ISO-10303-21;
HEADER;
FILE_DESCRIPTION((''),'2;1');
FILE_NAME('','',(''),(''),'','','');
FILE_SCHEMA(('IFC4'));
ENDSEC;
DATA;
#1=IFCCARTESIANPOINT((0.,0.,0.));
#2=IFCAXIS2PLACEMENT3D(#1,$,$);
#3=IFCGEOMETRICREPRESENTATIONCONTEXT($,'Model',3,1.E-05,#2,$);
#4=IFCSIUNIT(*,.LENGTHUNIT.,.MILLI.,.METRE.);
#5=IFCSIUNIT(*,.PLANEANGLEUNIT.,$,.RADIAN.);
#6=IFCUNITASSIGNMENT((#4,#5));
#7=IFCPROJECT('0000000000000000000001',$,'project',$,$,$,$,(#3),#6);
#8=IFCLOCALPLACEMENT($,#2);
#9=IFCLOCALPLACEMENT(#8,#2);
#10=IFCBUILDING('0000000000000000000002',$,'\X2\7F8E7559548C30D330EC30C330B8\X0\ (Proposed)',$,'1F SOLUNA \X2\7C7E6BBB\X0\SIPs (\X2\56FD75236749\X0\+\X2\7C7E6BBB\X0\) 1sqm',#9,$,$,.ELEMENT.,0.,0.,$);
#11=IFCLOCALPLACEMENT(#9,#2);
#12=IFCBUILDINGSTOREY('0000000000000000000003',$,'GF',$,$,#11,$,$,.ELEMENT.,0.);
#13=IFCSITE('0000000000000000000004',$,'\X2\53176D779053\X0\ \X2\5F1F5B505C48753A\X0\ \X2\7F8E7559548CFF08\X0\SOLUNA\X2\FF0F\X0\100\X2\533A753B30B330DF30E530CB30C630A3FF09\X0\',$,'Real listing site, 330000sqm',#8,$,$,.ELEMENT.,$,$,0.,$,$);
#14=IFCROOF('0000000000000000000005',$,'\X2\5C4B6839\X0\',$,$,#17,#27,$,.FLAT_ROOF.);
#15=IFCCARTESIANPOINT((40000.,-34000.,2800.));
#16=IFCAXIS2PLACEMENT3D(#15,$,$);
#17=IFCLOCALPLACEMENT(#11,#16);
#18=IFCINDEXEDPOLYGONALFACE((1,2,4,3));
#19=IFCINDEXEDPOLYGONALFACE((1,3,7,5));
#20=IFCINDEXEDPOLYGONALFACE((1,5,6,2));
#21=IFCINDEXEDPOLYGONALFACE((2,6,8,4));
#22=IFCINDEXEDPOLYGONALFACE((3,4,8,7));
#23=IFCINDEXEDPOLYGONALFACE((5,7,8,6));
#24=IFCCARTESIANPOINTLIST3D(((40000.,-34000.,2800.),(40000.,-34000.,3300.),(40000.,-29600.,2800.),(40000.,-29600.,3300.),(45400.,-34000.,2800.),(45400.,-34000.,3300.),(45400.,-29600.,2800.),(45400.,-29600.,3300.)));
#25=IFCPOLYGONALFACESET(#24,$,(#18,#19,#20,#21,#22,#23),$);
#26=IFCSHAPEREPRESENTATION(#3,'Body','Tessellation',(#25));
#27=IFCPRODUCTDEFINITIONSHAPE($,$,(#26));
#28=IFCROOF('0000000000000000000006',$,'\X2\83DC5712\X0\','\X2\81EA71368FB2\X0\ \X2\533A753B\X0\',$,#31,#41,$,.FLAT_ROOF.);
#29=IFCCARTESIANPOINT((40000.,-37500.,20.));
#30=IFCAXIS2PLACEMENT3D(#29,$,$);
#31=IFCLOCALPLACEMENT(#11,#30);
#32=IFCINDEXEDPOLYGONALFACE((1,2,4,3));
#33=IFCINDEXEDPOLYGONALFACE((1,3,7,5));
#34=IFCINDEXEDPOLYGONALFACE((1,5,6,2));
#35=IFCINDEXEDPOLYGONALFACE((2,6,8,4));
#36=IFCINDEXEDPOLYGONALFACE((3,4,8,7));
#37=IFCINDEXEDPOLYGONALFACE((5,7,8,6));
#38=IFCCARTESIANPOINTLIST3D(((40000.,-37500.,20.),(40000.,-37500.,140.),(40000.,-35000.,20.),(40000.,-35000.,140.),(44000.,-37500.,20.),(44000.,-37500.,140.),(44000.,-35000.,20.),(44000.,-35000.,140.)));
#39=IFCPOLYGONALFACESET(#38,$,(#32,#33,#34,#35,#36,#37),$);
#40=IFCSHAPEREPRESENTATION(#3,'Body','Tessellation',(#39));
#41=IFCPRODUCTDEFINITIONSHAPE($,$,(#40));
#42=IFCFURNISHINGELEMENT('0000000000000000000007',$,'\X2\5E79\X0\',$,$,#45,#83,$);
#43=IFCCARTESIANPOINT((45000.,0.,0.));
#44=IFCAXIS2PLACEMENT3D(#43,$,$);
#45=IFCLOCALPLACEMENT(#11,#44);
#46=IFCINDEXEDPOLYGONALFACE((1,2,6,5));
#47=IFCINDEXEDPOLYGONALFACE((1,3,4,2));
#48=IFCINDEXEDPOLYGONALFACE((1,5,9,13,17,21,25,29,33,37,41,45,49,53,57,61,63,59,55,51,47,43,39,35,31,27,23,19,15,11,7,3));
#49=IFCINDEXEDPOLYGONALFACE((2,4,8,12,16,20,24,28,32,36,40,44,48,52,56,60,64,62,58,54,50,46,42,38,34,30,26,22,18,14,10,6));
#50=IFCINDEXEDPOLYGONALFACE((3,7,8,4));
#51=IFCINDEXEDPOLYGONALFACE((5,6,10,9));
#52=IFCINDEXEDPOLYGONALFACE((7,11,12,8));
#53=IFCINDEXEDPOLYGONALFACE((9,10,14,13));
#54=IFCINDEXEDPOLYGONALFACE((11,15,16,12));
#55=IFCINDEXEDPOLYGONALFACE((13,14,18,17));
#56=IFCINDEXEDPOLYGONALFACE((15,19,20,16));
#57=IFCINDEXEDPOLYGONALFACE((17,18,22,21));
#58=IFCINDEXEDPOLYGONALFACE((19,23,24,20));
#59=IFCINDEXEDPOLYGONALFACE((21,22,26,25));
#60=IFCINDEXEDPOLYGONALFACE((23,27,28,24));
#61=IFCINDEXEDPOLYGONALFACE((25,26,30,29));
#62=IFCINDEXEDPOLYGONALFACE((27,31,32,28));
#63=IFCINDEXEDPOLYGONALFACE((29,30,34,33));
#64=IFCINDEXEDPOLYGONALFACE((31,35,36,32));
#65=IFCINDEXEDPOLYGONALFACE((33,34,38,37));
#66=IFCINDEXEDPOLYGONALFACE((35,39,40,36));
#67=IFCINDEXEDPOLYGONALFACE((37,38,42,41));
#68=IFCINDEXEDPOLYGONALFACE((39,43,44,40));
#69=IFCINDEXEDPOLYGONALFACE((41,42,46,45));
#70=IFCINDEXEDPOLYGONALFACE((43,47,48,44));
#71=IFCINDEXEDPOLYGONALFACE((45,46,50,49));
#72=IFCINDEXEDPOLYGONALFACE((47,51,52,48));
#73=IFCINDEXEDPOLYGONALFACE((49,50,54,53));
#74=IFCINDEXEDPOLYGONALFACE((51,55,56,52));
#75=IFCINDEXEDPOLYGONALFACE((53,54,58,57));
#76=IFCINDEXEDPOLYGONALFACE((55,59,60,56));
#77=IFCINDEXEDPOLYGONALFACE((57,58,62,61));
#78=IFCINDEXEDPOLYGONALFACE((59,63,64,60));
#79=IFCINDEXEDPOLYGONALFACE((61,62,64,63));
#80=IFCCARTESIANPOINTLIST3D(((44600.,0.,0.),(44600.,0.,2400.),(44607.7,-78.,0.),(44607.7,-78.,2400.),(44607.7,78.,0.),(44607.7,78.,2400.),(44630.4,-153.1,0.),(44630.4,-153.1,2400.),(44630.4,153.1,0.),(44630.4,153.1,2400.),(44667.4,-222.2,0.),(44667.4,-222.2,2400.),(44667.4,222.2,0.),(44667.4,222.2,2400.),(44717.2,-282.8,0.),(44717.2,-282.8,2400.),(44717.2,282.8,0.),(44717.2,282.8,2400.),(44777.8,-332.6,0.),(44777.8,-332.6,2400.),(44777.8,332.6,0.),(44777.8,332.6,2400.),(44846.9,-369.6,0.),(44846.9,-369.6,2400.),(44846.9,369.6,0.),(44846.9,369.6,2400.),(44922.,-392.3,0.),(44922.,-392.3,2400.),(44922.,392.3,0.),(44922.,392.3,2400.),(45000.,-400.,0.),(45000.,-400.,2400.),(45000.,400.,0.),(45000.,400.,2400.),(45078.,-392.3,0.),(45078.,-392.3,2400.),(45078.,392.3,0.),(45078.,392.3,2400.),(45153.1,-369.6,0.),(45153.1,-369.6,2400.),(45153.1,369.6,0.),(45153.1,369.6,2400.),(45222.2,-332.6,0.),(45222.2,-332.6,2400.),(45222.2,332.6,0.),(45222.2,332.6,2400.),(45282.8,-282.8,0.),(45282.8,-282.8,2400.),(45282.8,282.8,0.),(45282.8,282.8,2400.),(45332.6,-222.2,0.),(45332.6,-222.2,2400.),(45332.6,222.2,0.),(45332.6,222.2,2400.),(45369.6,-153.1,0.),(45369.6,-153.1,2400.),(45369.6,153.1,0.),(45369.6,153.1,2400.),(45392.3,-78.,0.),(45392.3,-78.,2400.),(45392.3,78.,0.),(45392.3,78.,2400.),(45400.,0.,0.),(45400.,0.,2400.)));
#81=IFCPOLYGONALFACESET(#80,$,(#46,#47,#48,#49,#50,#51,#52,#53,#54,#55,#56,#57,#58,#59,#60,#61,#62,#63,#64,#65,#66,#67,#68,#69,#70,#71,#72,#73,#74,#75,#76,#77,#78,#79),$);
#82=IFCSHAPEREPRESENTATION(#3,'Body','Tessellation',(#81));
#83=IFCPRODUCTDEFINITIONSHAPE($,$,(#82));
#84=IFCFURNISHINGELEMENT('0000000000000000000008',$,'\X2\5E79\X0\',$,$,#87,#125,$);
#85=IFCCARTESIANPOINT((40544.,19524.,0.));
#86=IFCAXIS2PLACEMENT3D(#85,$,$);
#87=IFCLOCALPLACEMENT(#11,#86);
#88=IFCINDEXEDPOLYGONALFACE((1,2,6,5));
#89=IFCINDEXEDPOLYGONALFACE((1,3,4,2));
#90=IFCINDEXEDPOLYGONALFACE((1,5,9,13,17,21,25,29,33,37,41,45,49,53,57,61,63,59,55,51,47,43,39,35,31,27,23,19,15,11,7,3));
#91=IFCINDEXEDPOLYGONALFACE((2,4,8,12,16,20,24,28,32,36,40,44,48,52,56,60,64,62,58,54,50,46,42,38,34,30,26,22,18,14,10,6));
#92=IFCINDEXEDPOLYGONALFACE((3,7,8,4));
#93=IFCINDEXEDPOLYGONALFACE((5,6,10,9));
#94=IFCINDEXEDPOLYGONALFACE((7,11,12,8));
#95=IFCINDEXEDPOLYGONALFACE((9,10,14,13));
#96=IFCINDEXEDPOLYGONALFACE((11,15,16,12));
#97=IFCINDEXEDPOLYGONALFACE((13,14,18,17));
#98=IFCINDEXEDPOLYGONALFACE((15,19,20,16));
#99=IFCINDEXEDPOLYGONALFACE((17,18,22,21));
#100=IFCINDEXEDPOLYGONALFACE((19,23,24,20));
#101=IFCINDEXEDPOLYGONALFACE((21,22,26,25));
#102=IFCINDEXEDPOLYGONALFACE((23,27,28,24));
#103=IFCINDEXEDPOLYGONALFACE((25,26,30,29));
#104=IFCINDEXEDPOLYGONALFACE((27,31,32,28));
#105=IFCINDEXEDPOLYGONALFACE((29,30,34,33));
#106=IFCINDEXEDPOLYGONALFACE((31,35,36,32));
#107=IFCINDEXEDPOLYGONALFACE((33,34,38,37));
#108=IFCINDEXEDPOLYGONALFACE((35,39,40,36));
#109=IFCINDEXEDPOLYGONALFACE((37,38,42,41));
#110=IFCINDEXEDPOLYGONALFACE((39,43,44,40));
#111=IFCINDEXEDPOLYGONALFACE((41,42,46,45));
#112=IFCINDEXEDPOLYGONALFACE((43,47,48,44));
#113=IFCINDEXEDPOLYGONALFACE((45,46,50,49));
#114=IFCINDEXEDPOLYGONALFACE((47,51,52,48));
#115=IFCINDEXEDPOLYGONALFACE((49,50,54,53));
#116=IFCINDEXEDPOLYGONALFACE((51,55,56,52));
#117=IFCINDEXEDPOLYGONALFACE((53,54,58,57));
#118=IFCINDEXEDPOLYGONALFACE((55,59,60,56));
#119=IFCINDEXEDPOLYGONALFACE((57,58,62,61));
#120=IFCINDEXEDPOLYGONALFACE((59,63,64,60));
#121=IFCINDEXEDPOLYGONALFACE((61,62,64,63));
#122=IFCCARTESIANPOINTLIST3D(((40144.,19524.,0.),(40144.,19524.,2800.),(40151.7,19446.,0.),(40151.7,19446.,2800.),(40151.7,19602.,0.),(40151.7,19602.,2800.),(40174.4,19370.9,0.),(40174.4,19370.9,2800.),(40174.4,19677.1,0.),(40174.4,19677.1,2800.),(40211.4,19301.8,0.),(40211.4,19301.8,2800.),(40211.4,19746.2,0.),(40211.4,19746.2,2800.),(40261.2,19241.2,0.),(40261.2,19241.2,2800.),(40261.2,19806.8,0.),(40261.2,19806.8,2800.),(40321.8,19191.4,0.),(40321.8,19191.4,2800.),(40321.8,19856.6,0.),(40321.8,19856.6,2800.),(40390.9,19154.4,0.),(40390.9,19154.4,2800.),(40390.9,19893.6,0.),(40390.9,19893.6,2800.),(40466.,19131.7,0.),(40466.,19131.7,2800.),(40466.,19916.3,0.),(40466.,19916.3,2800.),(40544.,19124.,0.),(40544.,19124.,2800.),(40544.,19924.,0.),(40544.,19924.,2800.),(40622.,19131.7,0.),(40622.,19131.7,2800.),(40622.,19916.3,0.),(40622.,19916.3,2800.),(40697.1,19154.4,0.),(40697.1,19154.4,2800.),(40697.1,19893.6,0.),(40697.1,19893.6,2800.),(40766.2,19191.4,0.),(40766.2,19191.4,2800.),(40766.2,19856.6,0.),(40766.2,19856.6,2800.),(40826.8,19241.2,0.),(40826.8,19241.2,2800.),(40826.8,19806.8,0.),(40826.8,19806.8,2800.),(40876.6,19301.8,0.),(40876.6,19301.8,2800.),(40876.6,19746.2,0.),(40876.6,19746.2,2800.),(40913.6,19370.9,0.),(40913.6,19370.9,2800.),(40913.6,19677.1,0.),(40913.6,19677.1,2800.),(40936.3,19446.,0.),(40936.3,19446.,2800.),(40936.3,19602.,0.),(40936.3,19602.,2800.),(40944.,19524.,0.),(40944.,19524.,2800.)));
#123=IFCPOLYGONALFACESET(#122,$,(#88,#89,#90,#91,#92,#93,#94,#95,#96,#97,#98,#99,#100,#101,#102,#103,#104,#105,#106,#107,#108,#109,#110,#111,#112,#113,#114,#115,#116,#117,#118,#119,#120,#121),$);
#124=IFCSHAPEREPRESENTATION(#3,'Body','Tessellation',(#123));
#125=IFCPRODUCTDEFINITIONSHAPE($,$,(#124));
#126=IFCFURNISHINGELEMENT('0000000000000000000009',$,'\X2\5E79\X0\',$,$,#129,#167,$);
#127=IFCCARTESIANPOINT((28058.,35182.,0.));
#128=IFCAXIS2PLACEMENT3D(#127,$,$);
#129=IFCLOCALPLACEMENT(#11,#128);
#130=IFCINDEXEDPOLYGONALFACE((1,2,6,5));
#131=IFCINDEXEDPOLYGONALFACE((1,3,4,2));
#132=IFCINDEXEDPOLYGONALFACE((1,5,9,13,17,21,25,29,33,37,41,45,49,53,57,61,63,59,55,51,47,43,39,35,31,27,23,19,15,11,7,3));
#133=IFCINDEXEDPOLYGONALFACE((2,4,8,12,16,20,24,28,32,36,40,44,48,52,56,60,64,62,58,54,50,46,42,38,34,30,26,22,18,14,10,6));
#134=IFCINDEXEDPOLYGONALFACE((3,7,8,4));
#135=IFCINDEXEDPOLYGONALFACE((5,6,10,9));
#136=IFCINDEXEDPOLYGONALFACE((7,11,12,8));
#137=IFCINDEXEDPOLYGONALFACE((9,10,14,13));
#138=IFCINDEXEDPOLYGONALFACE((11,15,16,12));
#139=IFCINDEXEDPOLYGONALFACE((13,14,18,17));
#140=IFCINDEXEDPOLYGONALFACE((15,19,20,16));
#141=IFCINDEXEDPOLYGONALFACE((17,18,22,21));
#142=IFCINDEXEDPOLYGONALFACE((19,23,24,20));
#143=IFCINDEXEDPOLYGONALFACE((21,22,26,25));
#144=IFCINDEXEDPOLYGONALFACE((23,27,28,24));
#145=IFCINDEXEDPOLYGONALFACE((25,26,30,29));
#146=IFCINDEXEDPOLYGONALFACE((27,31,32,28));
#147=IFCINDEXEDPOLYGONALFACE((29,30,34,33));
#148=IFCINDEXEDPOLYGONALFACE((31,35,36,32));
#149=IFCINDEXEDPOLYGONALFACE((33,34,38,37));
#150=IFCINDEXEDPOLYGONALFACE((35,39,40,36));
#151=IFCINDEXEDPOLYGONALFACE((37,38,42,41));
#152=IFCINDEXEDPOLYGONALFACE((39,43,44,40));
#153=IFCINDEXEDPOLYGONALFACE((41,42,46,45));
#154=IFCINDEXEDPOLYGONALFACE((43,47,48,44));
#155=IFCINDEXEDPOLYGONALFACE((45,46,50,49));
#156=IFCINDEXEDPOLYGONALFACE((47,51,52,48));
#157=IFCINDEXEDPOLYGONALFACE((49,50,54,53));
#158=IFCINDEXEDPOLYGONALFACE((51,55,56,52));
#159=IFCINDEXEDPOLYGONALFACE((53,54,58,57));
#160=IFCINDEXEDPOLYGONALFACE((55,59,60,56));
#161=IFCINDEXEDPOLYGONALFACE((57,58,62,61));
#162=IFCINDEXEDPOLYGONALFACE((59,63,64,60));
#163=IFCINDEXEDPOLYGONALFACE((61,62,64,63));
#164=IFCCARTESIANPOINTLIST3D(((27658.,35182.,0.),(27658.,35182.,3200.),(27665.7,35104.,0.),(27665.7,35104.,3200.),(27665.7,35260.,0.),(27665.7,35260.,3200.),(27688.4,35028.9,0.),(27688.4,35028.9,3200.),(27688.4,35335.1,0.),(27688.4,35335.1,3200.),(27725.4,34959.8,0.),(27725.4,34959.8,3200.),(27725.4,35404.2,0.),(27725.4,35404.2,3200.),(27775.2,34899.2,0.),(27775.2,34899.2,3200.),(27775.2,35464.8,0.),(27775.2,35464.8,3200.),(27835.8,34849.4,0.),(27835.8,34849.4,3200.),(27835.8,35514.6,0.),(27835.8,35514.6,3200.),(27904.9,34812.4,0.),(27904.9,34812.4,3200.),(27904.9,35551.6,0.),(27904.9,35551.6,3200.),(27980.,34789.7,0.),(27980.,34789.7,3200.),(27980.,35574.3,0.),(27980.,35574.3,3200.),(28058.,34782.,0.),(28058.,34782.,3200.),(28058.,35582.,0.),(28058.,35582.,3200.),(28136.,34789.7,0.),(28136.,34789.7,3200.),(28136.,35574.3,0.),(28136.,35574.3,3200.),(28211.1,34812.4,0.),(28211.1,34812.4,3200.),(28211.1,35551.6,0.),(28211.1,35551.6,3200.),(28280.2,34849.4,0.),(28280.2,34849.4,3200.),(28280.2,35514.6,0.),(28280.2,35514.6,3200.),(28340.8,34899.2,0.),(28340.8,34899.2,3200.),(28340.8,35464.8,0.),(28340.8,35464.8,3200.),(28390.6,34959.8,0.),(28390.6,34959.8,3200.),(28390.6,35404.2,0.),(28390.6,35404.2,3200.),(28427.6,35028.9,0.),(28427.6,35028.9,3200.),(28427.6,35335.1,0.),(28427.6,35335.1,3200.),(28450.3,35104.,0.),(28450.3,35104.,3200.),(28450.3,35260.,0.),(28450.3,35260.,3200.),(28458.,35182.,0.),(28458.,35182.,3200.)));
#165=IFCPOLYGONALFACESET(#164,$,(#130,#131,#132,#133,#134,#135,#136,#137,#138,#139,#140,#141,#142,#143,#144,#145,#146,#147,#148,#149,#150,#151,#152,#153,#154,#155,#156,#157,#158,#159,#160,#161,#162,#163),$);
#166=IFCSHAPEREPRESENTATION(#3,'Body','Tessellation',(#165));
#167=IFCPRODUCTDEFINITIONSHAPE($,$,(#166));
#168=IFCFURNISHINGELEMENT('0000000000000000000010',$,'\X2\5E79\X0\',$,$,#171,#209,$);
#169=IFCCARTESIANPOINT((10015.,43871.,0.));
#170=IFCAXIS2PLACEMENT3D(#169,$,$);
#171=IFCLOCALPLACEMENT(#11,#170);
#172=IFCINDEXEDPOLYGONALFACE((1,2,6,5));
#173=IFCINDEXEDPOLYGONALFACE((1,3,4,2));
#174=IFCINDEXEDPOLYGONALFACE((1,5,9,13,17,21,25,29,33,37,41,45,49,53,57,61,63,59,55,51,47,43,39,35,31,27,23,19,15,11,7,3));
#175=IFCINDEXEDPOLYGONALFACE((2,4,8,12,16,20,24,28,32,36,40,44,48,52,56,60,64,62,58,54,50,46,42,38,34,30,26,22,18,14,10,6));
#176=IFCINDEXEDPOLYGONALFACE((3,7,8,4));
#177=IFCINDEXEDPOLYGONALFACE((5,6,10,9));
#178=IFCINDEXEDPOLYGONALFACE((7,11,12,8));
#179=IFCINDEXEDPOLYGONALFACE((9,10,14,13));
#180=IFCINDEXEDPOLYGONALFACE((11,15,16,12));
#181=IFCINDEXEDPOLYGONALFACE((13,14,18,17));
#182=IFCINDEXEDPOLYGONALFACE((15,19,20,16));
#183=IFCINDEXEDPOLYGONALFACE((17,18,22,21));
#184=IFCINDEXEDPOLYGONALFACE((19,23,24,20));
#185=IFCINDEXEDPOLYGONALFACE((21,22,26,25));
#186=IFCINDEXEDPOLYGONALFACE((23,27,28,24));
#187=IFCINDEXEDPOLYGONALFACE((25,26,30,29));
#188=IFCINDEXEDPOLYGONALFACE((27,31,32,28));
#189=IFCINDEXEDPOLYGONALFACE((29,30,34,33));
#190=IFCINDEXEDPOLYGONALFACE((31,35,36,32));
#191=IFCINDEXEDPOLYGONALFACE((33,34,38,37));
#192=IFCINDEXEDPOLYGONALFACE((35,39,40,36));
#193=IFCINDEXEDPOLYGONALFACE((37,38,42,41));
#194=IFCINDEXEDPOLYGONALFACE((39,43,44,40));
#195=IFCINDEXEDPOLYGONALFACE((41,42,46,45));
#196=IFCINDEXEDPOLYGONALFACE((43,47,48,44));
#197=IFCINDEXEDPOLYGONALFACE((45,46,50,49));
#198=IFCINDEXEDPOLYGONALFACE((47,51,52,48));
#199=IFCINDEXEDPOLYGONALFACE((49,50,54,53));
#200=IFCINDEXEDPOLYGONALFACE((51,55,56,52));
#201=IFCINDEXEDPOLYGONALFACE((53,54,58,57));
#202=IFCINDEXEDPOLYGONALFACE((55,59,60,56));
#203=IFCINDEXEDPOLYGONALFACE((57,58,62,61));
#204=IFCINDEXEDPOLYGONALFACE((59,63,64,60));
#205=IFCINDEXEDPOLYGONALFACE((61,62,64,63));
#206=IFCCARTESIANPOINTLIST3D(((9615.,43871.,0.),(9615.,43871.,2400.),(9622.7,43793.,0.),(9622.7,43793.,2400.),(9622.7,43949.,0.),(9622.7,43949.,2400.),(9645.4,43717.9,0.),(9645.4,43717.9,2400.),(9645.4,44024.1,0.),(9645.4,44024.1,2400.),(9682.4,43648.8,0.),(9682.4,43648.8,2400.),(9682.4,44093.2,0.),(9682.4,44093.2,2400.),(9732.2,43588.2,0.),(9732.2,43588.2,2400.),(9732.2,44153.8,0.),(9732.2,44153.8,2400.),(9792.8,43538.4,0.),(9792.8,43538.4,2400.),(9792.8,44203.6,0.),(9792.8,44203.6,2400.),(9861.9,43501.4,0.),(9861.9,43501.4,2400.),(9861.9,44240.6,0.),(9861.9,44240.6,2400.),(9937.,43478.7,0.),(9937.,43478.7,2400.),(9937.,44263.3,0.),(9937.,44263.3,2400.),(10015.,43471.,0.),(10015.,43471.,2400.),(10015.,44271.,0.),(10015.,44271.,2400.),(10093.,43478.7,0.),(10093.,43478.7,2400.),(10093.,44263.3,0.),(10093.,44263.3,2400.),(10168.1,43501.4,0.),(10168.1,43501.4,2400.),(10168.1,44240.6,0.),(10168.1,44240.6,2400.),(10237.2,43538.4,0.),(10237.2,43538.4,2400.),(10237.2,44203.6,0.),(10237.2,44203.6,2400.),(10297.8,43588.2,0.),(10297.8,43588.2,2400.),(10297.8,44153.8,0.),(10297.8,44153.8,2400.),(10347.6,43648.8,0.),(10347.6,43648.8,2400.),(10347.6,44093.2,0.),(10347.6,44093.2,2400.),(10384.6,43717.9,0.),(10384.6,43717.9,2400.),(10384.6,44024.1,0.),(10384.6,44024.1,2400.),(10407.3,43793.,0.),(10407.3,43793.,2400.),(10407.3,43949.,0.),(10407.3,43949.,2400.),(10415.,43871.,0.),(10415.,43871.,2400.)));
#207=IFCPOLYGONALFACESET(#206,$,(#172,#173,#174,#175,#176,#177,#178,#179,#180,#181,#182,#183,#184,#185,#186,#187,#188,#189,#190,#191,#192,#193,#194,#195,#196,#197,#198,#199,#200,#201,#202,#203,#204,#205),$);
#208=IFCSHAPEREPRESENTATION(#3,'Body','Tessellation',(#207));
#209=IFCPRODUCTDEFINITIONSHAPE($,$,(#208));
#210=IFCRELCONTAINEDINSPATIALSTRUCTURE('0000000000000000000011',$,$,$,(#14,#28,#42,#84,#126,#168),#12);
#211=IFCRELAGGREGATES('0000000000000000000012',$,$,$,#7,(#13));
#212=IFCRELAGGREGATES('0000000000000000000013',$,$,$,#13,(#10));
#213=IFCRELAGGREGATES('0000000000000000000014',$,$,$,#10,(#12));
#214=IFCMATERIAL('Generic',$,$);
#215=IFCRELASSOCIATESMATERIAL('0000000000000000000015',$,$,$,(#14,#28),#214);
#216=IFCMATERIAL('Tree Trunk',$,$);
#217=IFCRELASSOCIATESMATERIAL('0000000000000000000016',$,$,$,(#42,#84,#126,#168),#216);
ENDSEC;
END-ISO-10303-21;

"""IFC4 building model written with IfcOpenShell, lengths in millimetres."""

from ifc_helpers import new_model, si_unit, frame, frame_2d, origin, origin_2d, place, context, project, spatial, rectangle, circle, extrude, material, element, save


model = new_model("IFC4")

# Units and contexts
model_context = context("Model", 3, precision=1e-05, world=origin())
ifc_project = project(units=[si_unit("LENGTHUNIT", "METRE", prefix="MILLI"), si_unit("PLANEANGLEUNIT", "RADIAN")], contexts=[model_context])

# Site, building, storey
site_placement = place(None, origin())
site = spatial("IfcSite", under=ifc_project, at=site_placement, Name="北海道 弟子屈町 美留和（SOLUNA／100区画コミュニティ）", ObjectType="Real listing site, 330000sqm", CompositionType="ELEMENT", RefElevation=0.0)
building_placement = place(site_placement, origin())
building = spatial("IfcBuilding", under=site, at=building_placement, Name="美留和ビレッジ (Proposed)", ObjectType="1F SOLUNA 籾殻SIPs (国産杉+籾殻) 1sqm", CompositionType="ELEMENT", ElevationOfRefHeight=0.0, ElevationOfTerrain=0.0)
storey_placement = place(building_placement, origin())
storey = spatial("IfcBuildingStorey", under=building, at=storey_placement, Name="GF", CompositionType="ELEMENT", Elevation=0.0)

# Shared definitions
ifc_material_1 = material(Name="Generic")

# Roofs
roof_1_placement = place(storey_placement, frame((40000.0, -34000.0, 2800.0)))
element("IfcRoof", 1, at=roof_1_placement, inside=storey, material=ifc_material_1, Name="屋根", PredefinedType="FLAT_ROOF", context=model_context, shape_type="SweptSolid", body=[
    extrude(rectangle(XDim=5400.0, YDim=4400.0, at=frame_2d((2700.0, 2200.0))), frame((40000.0, -34000.0, 2800.0)), (0.0, 0.0, 1.0), 500.0),
])
roof_2_placement = place(storey_placement, frame((40000.0, -37500.0, 20.0)))
element("IfcRoof", 2, at=roof_2_placement, inside=storey, material=ifc_material_1, Name="菜園", Description="自然農 区画", PredefinedType="FLAT_ROOF", context=model_context, shape_type="SweptSolid", body=[
    extrude(rectangle(XDim=4000.0, YDim=2500.0, at=frame_2d((2000.0, 1250.0))), frame((40000.0, -37500.0, 20.0)), (0.0, 0.0, 1.0), 120.0),
])

# Furnishing elements
ifc_material_2 = material(Name="Tree Trunk")
furnishing_1_placement = place(storey_placement, frame((45000.0, 0.0, 0.0)))
element("IfcFurnishingElement", 3, at=furnishing_1_placement, inside=storey, material=ifc_material_2, Name="幹", context=model_context, shape_type="SweptSolid", body=[
    extrude(circle(Radius=400.0, at=origin_2d()), frame((45000.0, 0.0, 0.0)), (0.0, 0.0, 1.0), 2400.0),
])
furnishing_2_placement = place(storey_placement, frame((40544.0, 19524.0, 0.0)))
element("IfcFurnishingElement", 4, at=furnishing_2_placement, inside=storey, material=ifc_material_2, Name="幹", context=model_context, shape_type="SweptSolid", body=[
    extrude(circle(Radius=400.0, at=origin_2d()), frame((40544.0, 19524.0, 0.0)), (0.0, 0.0, 1.0), 2800.0),
])
furnishing_3_placement = place(storey_placement, frame((28058.0, 35182.0, 0.0)))
element("IfcFurnishingElement", 5, at=furnishing_3_placement, inside=storey, material=ifc_material_2, Name="幹", context=model_context, shape_type="SweptSolid", body=[
    extrude(circle(Radius=400.0, at=origin_2d()), frame((28058.0, 35182.0, 0.0)), (0.0, 0.0, 1.0), 3200.0),
])
furnishing_4_placement = place(storey_placement, frame((10015.0, 43871.0, 0.0)))
element("IfcFurnishingElement", 6, at=furnishing_4_placement, inside=storey, material=ifc_material_2, Name="幹", context=model_context, shape_type="SweptSolid", body=[
    extrude(circle(Radius=400.0, at=origin_2d()), frame((10015.0, 43871.0, 0.0)), (0.0, 0.0, 1.0), 2400.0),
])

save(model, "model.ifc")
